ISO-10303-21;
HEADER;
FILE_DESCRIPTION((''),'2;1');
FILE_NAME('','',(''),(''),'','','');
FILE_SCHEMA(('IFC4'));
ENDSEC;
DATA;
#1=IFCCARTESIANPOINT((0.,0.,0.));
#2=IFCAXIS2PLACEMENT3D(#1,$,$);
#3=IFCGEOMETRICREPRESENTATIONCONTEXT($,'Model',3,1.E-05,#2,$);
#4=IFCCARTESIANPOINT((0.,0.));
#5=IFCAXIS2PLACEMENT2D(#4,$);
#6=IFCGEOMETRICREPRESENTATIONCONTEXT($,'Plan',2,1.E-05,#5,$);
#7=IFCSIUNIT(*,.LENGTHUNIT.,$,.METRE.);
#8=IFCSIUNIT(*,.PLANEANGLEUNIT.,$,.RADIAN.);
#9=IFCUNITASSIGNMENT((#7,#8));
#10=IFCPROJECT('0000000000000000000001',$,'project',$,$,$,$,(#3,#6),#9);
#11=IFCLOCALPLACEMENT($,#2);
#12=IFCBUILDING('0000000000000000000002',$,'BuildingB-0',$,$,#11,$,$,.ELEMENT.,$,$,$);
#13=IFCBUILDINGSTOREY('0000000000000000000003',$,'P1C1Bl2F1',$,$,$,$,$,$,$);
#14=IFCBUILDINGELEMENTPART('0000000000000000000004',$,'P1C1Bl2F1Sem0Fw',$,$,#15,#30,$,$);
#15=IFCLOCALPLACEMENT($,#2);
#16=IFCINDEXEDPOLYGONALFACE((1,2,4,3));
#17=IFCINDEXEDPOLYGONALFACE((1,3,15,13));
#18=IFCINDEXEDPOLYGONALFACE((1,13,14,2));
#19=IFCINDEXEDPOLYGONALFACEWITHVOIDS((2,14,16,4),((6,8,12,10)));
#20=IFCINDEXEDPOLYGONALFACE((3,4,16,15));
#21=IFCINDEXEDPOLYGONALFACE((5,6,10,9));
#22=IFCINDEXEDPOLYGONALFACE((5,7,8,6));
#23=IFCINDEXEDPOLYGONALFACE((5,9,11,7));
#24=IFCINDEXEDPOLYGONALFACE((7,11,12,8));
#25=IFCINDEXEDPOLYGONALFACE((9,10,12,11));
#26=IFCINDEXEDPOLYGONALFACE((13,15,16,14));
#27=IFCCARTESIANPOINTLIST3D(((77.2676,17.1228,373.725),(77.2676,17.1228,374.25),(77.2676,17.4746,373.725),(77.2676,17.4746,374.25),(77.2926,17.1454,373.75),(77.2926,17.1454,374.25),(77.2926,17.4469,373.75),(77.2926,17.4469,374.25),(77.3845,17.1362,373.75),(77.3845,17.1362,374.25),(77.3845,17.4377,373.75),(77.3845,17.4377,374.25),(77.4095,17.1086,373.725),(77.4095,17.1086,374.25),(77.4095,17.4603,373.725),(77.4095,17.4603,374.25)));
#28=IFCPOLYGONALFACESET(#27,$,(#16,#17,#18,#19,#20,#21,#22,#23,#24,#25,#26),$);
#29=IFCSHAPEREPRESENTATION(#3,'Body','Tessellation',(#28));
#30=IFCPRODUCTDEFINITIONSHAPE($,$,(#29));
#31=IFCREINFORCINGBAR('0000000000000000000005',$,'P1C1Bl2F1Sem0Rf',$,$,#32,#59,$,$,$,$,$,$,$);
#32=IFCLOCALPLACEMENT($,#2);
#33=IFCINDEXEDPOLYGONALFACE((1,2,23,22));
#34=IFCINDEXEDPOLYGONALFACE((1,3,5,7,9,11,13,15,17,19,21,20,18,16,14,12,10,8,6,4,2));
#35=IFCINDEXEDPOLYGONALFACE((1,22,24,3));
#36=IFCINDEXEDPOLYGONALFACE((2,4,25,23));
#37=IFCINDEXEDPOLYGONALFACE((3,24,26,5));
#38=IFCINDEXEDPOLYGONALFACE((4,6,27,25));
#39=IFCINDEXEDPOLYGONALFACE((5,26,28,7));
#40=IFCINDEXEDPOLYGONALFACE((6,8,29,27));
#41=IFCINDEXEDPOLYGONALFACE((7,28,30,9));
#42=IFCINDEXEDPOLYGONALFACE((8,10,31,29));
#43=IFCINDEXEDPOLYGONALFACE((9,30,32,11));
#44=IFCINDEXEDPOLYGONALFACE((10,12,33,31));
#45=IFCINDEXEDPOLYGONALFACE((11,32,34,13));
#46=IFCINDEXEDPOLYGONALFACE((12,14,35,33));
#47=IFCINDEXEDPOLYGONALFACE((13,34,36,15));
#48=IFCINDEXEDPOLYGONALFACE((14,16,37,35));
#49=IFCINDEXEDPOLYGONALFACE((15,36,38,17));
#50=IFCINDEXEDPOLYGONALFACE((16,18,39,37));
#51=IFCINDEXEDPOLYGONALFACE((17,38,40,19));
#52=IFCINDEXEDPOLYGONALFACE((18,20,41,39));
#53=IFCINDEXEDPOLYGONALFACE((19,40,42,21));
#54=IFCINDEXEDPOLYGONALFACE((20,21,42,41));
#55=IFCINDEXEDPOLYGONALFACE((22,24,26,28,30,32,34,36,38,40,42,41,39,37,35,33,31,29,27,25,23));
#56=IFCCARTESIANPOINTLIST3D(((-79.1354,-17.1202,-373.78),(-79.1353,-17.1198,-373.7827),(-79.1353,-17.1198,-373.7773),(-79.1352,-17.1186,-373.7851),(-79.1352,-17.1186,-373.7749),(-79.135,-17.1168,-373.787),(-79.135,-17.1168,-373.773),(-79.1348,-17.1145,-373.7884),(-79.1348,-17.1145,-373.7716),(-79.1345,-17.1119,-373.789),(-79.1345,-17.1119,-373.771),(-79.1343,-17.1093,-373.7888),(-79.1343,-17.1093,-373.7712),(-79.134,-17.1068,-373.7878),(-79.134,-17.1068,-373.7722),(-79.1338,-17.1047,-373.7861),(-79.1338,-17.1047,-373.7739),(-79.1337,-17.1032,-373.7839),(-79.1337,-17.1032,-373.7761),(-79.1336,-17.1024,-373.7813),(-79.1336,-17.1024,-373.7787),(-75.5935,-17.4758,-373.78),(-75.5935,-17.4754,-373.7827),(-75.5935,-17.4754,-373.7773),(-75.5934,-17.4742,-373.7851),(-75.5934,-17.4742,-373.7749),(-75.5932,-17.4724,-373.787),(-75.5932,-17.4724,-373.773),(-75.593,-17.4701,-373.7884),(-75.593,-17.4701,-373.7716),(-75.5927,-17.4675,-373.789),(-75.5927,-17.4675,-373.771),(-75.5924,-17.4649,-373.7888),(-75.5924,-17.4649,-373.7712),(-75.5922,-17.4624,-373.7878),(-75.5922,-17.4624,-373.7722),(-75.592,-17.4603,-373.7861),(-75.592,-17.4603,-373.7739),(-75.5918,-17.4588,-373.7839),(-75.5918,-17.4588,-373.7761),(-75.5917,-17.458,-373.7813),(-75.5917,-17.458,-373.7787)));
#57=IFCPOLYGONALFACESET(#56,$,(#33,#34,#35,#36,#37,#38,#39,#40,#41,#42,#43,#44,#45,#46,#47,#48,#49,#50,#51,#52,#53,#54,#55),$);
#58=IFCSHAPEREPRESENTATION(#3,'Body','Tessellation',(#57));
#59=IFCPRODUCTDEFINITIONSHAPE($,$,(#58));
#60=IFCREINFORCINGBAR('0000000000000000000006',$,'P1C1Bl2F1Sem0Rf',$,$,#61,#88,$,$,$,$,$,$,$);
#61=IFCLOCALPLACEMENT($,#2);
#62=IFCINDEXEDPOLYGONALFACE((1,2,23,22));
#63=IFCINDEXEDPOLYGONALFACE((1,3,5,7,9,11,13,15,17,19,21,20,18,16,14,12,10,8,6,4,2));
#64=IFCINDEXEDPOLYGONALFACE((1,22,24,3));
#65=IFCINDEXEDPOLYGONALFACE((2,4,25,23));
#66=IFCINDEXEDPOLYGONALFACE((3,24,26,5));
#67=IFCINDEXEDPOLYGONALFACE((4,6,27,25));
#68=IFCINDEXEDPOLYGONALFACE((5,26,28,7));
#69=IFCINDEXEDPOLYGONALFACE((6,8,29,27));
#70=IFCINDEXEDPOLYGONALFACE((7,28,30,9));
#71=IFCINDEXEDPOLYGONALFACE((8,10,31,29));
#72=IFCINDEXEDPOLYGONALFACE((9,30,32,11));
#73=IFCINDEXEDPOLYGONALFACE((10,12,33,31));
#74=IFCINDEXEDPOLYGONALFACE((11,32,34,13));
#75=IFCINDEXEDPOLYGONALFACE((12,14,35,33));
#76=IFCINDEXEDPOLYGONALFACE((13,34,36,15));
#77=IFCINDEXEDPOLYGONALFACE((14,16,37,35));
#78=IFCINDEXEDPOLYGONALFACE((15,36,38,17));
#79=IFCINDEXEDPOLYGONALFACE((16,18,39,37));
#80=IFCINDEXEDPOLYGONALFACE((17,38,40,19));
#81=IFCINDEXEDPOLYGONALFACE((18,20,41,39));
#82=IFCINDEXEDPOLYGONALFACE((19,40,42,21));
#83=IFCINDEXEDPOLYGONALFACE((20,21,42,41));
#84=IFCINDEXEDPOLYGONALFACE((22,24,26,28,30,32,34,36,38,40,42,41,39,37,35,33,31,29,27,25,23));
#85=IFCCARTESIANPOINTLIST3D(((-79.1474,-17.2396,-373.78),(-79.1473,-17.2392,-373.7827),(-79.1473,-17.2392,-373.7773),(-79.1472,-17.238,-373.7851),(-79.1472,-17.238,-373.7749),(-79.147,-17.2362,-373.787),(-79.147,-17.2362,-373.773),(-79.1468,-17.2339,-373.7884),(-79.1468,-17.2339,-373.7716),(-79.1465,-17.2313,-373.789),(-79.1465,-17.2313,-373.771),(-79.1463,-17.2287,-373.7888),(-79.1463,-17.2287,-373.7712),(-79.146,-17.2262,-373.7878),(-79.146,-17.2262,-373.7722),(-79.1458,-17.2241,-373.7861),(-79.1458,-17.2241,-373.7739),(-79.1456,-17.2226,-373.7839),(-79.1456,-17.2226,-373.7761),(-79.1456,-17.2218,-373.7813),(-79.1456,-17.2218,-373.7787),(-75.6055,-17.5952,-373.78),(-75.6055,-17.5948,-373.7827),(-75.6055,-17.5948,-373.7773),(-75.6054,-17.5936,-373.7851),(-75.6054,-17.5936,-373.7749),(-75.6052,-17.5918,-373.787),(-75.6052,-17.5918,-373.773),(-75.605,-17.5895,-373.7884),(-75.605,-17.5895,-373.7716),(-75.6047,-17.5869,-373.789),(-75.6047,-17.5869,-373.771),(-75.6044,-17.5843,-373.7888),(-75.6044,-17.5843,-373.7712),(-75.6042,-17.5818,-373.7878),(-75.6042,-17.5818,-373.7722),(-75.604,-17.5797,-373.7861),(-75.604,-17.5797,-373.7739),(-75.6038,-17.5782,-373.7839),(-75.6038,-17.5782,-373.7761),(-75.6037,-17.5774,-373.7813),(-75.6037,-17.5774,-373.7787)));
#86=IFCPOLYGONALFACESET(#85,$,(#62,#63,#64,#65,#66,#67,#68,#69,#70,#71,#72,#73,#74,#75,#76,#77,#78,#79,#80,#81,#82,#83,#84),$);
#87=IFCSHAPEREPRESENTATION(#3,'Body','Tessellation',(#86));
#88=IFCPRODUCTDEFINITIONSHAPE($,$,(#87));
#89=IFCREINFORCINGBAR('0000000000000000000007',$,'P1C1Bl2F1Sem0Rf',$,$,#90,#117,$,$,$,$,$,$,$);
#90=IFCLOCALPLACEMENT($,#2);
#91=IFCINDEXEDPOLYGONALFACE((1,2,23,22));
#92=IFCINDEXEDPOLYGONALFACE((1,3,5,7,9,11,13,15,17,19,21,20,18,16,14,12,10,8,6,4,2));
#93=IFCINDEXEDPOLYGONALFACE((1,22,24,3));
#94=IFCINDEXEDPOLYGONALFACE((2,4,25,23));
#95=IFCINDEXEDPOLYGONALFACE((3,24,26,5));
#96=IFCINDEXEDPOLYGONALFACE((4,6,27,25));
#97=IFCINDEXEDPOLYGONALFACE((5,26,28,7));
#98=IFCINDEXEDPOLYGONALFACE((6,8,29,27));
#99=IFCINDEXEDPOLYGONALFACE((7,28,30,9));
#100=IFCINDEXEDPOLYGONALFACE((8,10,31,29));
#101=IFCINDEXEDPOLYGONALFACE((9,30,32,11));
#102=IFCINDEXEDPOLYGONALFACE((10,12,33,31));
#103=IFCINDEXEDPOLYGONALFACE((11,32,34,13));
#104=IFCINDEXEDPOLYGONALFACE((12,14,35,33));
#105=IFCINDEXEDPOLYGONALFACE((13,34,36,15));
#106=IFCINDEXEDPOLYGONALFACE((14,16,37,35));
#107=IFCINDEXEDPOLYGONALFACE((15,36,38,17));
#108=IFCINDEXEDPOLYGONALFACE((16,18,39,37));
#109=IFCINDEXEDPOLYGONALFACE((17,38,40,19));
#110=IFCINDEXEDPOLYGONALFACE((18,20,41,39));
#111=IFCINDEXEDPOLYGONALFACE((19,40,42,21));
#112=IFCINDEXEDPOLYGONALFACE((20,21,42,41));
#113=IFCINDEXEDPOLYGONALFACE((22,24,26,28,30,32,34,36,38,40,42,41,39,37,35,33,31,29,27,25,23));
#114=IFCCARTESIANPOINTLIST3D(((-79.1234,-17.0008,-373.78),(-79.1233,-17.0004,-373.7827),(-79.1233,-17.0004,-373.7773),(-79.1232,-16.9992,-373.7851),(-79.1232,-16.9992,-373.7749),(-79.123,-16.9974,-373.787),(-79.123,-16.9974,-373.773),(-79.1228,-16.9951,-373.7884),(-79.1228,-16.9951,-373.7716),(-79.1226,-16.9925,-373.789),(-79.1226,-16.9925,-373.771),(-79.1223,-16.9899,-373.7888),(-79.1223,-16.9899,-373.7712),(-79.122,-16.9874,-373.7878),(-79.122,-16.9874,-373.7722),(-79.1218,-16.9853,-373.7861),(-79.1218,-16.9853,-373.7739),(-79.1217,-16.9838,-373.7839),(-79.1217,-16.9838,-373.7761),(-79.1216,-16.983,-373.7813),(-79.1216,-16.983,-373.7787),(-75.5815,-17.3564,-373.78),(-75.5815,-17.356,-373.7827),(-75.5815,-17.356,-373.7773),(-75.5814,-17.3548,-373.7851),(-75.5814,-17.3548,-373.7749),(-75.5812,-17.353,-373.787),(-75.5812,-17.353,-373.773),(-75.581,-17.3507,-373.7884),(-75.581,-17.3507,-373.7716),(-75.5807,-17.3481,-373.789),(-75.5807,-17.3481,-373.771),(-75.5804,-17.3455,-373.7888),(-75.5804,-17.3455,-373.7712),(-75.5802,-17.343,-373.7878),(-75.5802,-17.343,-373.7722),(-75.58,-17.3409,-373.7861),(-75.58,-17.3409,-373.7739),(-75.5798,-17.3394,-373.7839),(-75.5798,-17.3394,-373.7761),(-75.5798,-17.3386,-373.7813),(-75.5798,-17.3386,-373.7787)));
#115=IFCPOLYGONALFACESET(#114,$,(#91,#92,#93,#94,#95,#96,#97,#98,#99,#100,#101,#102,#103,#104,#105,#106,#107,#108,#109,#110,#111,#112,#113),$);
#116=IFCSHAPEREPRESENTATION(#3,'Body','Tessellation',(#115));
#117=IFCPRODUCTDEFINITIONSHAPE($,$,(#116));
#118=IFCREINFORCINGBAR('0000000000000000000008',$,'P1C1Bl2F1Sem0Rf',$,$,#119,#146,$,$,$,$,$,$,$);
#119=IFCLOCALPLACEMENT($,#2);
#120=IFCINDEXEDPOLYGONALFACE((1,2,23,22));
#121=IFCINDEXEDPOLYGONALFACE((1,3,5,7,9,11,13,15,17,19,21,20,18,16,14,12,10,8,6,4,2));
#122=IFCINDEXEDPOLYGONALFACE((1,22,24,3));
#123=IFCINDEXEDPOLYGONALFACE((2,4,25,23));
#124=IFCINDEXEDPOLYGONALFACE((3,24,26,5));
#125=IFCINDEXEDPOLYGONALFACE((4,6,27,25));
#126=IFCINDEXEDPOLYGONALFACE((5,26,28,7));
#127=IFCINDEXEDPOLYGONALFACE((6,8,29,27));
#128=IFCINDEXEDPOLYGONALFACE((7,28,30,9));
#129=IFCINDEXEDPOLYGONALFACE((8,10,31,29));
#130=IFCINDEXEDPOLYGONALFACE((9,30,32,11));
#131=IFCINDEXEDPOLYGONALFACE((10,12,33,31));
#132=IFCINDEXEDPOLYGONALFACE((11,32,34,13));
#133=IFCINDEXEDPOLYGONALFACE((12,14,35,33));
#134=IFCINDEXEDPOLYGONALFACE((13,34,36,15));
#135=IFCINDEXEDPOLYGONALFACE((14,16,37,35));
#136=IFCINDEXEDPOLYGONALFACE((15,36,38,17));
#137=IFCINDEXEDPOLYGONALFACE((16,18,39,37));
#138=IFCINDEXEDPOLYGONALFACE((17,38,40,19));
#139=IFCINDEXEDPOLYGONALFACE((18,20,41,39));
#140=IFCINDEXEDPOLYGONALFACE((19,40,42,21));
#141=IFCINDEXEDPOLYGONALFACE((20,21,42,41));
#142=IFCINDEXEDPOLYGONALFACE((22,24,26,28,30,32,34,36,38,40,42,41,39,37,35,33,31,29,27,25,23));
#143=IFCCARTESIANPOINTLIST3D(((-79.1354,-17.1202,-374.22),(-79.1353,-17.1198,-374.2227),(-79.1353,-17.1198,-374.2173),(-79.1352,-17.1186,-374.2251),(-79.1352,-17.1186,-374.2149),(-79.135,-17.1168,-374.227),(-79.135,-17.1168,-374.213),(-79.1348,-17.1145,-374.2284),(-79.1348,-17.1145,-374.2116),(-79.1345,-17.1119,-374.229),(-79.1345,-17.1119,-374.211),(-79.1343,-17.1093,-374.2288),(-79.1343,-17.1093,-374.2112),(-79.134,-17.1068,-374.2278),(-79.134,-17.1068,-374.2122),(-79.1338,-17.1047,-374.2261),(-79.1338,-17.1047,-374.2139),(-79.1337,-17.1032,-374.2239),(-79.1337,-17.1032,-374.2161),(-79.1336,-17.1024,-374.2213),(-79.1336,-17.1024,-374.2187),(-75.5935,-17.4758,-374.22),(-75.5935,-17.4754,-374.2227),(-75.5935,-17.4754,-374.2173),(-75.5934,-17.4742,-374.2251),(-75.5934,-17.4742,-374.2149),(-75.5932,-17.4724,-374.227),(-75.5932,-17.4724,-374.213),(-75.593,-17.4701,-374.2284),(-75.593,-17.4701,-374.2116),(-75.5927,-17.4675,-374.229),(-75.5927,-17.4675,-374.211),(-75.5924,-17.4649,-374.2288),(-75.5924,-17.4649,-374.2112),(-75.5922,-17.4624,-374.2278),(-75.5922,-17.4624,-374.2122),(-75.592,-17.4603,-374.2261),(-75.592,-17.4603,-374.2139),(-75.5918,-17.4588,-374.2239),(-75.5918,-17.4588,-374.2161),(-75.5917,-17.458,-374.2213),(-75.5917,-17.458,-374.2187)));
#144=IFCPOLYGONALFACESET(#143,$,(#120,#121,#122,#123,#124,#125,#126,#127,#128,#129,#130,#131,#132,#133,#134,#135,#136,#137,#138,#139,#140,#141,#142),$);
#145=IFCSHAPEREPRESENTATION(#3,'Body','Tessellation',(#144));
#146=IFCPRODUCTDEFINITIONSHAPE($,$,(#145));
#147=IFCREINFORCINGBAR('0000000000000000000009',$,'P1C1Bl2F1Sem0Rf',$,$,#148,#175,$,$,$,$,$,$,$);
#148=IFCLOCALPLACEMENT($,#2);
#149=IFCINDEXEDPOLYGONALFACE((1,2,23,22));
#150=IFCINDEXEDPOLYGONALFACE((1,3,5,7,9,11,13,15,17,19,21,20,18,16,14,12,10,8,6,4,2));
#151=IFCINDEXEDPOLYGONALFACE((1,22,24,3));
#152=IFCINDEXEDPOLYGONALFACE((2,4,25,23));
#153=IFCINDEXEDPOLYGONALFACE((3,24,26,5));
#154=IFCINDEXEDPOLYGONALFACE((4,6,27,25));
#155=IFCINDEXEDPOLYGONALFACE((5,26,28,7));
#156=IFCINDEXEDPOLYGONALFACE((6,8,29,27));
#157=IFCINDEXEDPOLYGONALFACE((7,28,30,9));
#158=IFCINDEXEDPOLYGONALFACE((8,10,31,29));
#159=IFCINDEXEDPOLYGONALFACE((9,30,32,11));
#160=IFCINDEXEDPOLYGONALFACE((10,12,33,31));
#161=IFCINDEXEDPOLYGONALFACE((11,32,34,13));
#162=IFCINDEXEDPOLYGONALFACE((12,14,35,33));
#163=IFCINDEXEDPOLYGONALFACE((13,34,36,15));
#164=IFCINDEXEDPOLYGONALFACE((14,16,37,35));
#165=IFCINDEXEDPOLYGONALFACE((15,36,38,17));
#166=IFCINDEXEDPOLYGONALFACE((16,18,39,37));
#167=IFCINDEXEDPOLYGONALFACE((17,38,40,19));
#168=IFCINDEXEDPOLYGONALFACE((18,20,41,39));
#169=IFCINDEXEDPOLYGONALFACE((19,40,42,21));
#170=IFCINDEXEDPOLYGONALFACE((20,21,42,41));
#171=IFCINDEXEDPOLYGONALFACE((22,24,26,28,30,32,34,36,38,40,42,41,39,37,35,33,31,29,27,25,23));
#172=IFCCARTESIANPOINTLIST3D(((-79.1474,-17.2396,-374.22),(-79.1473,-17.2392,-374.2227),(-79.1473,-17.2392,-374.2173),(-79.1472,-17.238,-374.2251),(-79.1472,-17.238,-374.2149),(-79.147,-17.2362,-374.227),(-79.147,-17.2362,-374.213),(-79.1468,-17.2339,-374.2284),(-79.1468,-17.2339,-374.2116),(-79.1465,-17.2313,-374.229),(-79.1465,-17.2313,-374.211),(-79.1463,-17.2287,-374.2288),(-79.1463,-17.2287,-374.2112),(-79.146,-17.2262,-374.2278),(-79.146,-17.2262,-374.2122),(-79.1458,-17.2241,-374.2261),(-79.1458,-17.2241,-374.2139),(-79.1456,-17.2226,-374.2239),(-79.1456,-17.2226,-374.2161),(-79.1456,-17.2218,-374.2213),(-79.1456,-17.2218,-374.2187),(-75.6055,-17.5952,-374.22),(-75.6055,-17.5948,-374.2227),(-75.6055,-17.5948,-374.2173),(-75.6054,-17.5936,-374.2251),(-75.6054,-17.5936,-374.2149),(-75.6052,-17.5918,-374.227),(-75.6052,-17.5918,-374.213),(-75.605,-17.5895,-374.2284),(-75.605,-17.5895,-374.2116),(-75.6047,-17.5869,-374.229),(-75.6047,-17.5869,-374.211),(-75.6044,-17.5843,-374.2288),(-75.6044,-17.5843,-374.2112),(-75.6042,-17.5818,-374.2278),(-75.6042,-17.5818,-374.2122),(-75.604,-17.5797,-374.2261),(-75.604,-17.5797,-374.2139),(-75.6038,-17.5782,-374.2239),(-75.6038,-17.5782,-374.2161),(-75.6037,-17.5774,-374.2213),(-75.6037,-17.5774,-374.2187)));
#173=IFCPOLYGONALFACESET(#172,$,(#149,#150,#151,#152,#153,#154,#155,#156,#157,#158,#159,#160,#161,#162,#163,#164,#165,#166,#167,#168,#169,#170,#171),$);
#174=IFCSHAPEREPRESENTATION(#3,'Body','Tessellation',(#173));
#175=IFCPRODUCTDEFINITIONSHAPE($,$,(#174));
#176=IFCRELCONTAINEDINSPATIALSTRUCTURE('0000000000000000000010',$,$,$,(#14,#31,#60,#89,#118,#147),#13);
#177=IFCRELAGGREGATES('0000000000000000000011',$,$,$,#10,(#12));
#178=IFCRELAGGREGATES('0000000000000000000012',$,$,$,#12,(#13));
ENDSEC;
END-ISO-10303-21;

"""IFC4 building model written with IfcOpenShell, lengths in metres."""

from ifc_helpers import new_model, entity, si_unit, origin, origin_2d, place, context, project, spatial, polyline, outline, extrude, element, save


model = new_model("IFC4")

# Units and contexts
model_context = context("Model", 3, precision=1e-05, world=origin())
plan_context = context("Plan", 2, precision=1e-05, world=origin_2d())
ifc_project = project(units=[si_unit("LENGTHUNIT", "METRE"), si_unit("PLANEANGLEUNIT", "RADIAN")], contexts=[model_context, plan_context])

# Building, storey
building_placement = place(None, origin())
building = spatial("IfcBuilding", under=ifc_project, at=building_placement, Name="BuildingB-0", CompositionType="ELEMENT")
storey = spatial("IfcBuildingStorey", under=building, Name="P1C1Bl2F1")

# Building element part, opening
building_element_part_1 = element("IfcBuildingElementPart", 1, inside=storey, Name="P1C1Bl2F1Sem0Fw", context=model_context, shape_type="SweptSolid", body=[
    extrude(outline(polyline([(77.4095, 17.1086, 373.725), (77.2676, 17.1228, 373.725), (77.2676, 17.4746, 373.725), (77.4095, 17.4603, 373.725), (77.4095, 17.1086, 373.725)])), None, (0.0, 0.0, 1.0), 0.525),
])
element("IfcOpeningElement", 2, inside=storey, cuts=building_element_part_1, context=model_context, shape_type="SweptSolid", body=[
    extrude(outline(polyline([(77.3845, 17.1362, 373.75), (77.2926, 17.1454, 373.75), (77.2926, 17.4469, 373.75), (77.3845, 17.4377, 373.75), (77.3845, 17.1362, 373.75)])), None, (0.0, 0.0, 1.0), 0.5),
])

# Reinforcing bars
element("IfcReinforcingBar", 3, inside=storey, Name="P1C1Bl2F1Sem0Rf", context=model_context, shape_type="SweptSolid", body=[
    entity("IfcSurfaceCurveSweptAreaSolid", entity("IfcCircleProfileDef", "AREA", None, None, 0.009), None, entity("IfcPolyline", [entity("IfcCartesianPoint", [79.1345, 17.1112, 373.78]), entity("IfcCartesianPoint", [75.5926, 17.4668, 373.78])]), None, None, entity("IfcPlane", entity("IfcAxis2Placement3D", entity("IfcCartesianPoint", [79.1345, 17.1112, 373.78]), entity("IfcDirection", [0.0, 0.0, 1.0]), entity("IfcDirection", [1.0, 0.0, 0.0])))),
])
element("IfcReinforcingBar", 4, inside=storey, Name="P1C1Bl2F1Sem0Rf", context=model_context, shape_type="SweptSolid", body=[
    entity("IfcSurfaceCurveSweptAreaSolid", entity("IfcCircleProfileDef", "AREA", None, None, 0.009), None, entity("IfcPolyline", [entity("IfcCartesianPoint", [79.1465, 17.2306, 373.78]), entity("IfcCartesianPoint", [75.6046, 17.5862, 373.78])]), None, None, entity("IfcPlane", entity("IfcAxis2Placement3D", entity("IfcCartesianPoint", [79.1465, 17.2306, 373.78]), entity("IfcDirection", [0.0, 0.0, 1.0]), entity("IfcDirection", [1.0, 0.0, 0.0])))),
])
element("IfcReinforcingBar", 5, inside=storey, Name="P1C1Bl2F1Sem0Rf", context=model_context, shape_type="SweptSolid", body=[
    entity("IfcSurfaceCurveSweptAreaSolid", entity("IfcCircleProfileDef", "AREA", None, None, 0.009), None, entity("IfcPolyline", [entity("IfcCartesianPoint", [79.1225, 16.9918, 373.78]), entity("IfcCartesianPoint", [75.5806, 17.3474, 373.78])]), None, None, entity("IfcPlane", entity("IfcAxis2Placement3D", entity("IfcCartesianPoint", [79.1225, 16.9918, 373.78]), entity("IfcDirection", [0.0, 0.0, 1.0]), entity("IfcDirection", [1.0, 0.0, 0.0])))),
])
element("IfcReinforcingBar", 6, inside=storey, Name="P1C1Bl2F1Sem0Rf", context=model_context, shape_type="SweptSolid", body=[
    entity("IfcSurfaceCurveSweptAreaSolid", entity("IfcCircleProfileDef", "AREA", None, None, 0.009), None, entity("IfcPolyline", [entity("IfcCartesianPoint", [79.1345, 17.1112, 374.22]), entity("IfcCartesianPoint", [75.5926, 17.4668, 374.22])]), None, None, entity("IfcPlane", entity("IfcAxis2Placement3D", entity("IfcCartesianPoint", [79.1345, 17.1112, 374.22]), entity("IfcDirection", [0.0, 0.0, 1.0]), entity("IfcDirection", [1.0, 0.0, 0.0])))),
])
element("IfcReinforcingBar", 7, inside=storey, Name="P1C1Bl2F1Sem0Rf", context=model_context, shape_type="SweptSolid", body=[
    entity("IfcSurfaceCurveSweptAreaSolid", entity("IfcCircleProfileDef", "AREA", None, None, 0.009), None, entity("IfcPolyline", [entity("IfcCartesianPoint", [79.1465, 17.2306, 374.22]), entity("IfcCartesianPoint", [75.6046, 17.5862, 374.22])]), None, None, entity("IfcPlane", entity("IfcAxis2Placement3D", entity("IfcCartesianPoint", [79.1465, 17.2306, 374.22]), entity("IfcDirection", [0.0, 0.0, 1.0]), entity("IfcDirection", [1.0, 0.0, 0.0])))),
])

save(model, "model.ifc")
